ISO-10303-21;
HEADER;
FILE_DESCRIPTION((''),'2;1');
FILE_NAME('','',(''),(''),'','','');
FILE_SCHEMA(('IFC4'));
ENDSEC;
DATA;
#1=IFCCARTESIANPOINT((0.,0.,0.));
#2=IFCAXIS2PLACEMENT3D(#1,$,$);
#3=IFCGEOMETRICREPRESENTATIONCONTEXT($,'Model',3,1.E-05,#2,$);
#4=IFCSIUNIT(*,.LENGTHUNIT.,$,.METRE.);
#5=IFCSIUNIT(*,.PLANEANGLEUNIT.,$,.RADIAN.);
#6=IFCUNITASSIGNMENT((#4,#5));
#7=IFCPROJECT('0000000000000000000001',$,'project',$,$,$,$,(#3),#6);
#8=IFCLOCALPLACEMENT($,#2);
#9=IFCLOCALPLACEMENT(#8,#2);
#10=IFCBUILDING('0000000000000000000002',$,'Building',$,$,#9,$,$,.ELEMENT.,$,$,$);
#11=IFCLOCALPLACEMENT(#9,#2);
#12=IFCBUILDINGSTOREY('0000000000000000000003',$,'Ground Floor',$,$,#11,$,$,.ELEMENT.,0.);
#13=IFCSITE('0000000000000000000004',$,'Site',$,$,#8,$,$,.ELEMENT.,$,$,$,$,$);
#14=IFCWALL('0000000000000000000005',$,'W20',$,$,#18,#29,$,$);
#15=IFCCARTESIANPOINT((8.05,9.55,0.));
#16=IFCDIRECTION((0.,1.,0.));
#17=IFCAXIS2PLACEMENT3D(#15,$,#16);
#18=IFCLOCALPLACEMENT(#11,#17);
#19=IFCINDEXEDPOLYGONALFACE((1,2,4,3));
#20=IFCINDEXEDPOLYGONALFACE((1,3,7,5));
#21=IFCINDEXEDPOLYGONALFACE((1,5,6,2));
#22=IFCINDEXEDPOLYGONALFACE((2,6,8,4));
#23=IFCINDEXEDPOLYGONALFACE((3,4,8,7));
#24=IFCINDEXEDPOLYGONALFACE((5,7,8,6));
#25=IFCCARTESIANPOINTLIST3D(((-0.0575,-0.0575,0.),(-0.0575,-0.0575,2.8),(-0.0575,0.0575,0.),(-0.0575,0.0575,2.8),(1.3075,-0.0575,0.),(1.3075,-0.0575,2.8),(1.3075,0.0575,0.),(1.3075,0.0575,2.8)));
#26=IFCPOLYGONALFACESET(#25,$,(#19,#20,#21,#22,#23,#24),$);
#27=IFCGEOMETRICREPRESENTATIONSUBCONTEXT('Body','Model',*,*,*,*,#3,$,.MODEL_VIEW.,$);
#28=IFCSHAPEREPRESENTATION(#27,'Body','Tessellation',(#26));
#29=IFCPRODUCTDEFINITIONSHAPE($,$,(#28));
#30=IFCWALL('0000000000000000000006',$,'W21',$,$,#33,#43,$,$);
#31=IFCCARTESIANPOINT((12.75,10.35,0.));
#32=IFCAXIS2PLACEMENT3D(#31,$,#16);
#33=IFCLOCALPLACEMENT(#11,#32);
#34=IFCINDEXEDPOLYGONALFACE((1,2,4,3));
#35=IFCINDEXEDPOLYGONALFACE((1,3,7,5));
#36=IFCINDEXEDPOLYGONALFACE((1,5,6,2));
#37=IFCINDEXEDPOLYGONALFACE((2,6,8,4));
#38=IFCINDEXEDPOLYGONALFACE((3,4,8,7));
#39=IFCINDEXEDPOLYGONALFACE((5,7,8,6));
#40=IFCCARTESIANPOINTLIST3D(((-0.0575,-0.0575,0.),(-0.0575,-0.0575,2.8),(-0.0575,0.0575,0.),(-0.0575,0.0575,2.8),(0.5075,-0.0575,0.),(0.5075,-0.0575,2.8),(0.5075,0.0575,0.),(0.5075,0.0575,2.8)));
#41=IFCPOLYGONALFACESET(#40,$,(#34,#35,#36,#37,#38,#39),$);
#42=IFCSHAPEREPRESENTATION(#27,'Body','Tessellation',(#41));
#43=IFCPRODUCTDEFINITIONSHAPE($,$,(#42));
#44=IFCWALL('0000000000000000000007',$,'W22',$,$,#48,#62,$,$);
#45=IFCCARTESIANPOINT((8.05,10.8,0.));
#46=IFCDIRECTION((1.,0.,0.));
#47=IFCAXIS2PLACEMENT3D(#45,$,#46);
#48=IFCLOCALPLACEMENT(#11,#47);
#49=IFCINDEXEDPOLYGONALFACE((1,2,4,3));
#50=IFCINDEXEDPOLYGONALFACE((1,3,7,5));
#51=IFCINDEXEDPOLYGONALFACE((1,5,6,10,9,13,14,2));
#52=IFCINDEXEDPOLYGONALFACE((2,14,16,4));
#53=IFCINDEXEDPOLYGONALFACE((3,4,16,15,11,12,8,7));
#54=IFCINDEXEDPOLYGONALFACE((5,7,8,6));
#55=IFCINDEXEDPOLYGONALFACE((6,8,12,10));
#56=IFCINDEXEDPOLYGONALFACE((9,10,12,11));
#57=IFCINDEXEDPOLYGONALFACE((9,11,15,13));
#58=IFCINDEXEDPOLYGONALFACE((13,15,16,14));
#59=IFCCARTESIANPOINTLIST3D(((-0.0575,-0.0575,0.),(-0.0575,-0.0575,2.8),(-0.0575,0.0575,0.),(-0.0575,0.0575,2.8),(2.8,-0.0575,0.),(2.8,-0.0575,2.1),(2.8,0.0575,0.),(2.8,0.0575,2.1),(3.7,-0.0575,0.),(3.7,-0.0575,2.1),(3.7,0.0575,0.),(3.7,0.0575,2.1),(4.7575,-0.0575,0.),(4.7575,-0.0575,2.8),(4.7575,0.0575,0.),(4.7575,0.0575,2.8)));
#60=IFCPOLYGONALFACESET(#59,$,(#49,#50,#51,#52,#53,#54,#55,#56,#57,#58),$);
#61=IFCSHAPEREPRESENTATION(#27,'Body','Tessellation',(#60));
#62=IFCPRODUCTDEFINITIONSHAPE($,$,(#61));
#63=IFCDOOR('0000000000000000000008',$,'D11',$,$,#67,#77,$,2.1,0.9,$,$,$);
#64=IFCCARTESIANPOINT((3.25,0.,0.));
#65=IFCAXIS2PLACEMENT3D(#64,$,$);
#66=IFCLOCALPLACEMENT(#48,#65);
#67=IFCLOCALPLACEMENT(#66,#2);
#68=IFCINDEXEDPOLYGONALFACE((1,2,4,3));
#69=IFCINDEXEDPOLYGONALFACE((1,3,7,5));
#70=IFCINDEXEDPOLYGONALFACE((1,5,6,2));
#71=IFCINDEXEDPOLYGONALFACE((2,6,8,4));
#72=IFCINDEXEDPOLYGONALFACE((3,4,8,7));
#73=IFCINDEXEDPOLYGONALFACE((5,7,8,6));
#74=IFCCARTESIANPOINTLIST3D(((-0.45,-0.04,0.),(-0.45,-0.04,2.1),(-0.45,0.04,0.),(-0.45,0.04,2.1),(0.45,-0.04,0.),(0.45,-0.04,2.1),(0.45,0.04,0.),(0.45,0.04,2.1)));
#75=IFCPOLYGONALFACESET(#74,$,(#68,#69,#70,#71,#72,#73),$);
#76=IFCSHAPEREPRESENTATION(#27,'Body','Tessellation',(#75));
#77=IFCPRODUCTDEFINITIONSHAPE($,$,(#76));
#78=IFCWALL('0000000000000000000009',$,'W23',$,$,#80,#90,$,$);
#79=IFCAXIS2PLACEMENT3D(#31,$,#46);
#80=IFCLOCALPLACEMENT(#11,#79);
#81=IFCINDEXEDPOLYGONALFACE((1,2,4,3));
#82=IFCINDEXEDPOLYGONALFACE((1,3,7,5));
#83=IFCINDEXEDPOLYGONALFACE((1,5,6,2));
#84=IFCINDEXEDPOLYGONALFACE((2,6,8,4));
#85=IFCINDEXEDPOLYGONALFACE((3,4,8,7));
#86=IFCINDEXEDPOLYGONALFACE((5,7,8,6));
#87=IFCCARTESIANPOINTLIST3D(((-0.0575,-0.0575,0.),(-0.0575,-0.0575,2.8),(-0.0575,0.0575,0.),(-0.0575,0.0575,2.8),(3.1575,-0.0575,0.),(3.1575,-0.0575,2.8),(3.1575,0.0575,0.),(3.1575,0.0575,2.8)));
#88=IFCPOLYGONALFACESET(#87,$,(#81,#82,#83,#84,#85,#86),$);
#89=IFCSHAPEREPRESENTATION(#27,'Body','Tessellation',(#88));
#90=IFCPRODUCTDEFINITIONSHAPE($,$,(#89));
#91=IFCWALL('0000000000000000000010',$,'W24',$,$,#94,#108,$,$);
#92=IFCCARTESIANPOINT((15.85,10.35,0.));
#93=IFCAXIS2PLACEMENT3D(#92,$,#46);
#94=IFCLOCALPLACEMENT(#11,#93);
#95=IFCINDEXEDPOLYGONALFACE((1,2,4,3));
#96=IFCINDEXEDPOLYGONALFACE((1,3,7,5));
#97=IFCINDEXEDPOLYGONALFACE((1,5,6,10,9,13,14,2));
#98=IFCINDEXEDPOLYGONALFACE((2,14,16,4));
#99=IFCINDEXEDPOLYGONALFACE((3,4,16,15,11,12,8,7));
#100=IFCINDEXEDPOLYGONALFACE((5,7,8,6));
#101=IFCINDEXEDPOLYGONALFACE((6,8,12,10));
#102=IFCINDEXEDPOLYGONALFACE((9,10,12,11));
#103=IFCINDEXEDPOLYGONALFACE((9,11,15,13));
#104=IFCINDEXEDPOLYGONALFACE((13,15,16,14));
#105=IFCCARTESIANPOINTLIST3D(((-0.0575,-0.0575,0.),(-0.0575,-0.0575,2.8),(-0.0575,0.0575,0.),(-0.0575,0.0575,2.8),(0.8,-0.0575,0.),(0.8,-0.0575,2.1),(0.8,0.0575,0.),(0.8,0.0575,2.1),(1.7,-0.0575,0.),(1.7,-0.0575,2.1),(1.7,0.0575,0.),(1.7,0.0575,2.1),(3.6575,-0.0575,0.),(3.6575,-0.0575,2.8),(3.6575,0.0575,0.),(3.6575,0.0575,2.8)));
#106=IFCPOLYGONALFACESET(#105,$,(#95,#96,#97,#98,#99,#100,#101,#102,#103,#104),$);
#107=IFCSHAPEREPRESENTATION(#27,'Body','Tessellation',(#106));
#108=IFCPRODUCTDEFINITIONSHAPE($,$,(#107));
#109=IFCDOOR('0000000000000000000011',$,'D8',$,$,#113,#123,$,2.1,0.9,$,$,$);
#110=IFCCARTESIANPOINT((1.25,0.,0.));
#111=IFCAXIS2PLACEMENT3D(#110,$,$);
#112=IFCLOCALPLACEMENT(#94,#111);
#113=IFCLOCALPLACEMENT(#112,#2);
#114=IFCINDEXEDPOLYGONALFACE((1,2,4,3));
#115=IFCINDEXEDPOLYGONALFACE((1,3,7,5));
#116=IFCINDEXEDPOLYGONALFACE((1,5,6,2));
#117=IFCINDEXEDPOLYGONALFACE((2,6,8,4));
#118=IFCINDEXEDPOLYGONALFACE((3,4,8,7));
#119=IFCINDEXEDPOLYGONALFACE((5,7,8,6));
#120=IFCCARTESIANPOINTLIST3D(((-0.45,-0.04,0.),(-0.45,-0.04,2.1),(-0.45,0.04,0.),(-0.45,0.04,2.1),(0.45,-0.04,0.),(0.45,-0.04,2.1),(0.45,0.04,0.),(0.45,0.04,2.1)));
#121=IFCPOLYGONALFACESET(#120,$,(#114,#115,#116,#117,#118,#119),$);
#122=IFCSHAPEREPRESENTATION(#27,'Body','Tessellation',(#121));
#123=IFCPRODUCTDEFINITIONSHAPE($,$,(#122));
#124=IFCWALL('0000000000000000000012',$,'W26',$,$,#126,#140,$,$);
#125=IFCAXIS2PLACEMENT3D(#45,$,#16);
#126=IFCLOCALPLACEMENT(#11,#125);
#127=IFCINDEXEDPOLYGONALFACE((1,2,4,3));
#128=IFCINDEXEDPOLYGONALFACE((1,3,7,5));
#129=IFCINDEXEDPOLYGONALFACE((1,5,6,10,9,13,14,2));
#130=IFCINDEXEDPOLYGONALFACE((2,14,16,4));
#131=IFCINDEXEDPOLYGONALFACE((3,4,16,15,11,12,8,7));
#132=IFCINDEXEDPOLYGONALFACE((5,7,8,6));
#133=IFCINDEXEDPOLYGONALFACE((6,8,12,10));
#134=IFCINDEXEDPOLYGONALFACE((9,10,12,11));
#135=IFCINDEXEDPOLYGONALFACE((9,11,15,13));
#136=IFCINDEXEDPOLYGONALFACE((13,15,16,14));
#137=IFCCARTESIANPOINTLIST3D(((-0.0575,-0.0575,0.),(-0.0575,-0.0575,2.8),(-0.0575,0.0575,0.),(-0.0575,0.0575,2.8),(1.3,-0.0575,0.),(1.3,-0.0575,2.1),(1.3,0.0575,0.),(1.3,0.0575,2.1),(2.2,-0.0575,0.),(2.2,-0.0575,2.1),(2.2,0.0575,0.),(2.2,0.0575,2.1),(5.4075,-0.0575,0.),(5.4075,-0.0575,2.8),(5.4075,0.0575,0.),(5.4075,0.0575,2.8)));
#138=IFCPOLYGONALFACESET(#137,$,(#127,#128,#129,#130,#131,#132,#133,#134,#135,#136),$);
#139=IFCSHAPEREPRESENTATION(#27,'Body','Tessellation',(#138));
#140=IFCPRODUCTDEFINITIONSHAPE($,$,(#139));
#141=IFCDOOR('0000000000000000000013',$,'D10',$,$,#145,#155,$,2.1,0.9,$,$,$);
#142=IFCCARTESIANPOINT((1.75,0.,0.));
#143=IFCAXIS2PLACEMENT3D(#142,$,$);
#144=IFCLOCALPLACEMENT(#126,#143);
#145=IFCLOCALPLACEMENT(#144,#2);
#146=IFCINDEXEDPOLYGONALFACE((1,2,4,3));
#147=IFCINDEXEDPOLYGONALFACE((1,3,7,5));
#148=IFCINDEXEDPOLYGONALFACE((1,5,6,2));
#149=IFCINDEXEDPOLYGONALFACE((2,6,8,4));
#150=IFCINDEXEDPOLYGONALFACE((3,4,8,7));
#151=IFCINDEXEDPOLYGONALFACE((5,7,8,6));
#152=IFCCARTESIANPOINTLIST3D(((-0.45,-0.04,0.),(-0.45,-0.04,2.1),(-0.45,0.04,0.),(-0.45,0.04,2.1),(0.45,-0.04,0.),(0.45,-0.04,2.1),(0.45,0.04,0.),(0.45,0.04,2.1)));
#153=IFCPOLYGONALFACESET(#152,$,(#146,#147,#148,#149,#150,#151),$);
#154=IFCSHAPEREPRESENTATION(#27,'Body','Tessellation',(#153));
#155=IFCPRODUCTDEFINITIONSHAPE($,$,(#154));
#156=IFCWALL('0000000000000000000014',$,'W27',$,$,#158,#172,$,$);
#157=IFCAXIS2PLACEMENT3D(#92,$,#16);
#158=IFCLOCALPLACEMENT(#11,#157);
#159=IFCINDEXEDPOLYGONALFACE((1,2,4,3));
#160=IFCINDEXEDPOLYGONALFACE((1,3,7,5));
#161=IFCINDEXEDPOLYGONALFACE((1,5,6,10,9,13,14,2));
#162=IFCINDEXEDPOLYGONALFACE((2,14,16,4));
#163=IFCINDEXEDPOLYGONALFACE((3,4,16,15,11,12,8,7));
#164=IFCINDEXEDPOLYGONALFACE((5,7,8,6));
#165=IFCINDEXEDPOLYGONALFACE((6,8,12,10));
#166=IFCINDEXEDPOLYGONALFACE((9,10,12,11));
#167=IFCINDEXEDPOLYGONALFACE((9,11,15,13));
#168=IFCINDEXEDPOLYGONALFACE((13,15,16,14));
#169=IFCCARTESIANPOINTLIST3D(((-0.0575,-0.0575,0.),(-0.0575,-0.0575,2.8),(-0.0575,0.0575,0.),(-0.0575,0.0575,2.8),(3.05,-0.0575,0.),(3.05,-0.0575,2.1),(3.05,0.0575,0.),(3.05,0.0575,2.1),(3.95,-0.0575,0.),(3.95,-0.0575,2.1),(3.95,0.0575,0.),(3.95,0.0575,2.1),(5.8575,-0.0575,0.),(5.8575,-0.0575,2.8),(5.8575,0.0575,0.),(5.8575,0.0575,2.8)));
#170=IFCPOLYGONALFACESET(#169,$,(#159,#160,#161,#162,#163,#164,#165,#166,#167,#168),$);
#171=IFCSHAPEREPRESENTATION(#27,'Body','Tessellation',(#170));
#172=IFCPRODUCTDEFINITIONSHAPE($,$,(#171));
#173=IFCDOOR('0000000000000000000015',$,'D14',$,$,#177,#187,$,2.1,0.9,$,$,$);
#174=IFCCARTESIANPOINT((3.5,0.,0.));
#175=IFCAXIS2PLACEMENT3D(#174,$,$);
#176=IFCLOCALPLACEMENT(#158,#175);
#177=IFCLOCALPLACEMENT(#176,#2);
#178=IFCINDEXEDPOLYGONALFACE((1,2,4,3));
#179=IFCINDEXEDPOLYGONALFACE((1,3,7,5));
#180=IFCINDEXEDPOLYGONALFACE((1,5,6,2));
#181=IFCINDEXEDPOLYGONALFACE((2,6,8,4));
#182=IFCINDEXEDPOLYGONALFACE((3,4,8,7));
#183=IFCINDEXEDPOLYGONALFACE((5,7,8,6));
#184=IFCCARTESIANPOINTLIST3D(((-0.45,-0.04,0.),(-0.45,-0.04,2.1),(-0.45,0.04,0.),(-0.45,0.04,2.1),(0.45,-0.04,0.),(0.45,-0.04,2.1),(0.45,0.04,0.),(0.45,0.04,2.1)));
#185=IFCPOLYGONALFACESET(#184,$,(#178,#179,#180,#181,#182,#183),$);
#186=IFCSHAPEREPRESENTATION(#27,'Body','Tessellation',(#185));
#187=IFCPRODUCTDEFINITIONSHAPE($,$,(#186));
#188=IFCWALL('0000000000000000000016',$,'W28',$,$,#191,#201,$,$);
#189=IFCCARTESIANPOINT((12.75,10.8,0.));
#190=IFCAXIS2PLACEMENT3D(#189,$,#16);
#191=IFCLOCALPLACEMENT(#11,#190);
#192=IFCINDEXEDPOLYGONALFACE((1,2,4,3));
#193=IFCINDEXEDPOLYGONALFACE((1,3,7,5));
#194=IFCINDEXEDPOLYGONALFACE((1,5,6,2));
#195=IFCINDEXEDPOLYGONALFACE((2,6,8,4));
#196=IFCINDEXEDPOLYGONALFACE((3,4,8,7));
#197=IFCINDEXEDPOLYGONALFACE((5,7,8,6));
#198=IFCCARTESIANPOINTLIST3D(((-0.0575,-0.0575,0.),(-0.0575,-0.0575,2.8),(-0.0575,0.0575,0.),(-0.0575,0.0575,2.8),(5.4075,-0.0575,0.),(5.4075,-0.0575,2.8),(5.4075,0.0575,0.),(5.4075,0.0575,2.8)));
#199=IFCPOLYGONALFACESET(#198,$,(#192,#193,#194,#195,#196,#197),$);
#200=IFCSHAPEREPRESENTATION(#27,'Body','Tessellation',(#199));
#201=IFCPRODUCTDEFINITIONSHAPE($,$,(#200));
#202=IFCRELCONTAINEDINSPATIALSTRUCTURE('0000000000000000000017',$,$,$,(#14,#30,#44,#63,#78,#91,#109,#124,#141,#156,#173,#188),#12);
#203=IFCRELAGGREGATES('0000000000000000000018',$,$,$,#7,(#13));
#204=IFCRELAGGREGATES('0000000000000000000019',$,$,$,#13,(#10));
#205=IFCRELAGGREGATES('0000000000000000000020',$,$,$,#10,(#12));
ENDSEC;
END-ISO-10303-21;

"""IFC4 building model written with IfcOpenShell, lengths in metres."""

from ifc_helpers import new_model, si_unit, frame, frame_2d, origin, origin_2d, place, context, subcontext, project, spatial, rectangle, extrude, element, fill, save


model = new_model("IFC4")

# Units and contexts
model_context = context("Model", 3, precision=1e-05, world=origin())
body_context = subcontext(model_context, "Body", "Model", "MODEL_VIEW")
ifc_project = project(units=[si_unit("LENGTHUNIT", "METRE"), si_unit("PLANEANGLEUNIT", "RADIAN")], contexts=[model_context])

# Site, building, storey
site_placement = place(None, origin())
site = spatial("IfcSite", under=ifc_project, at=site_placement, Name="Site", CompositionType="ELEMENT")
building_placement = place(site_placement, origin())
building = spatial("IfcBuilding", under=site, at=building_placement, Name="Building", CompositionType="ELEMENT")
storey_placement = place(building_placement, origin())
storey = spatial("IfcBuildingStorey", under=building, at=storey_placement, Name="Ground Floor", CompositionType="ELEMENT", Elevation=0.0)

# Walls
wall_1_placement = place(storey_placement, frame((8.05, 9.55, 0.0), x_axis=(0.0, 1.0, 0.0)))
element("IfcWall", 1, at=wall_1_placement, inside=storey, Name="W20", context=body_context, shape_type="SweptSolid", body=[
    extrude(rectangle(XDim=1.365, YDim=0.115, at=frame_2d((0.625, 0.0))), origin(), (0.0, 0.0, 1.0), 2.8),
])
wall_2_placement = place(storey_placement, frame((12.75, 10.35, 0.0), x_axis=(0.0, 1.0, 0.0)))
element("IfcWall", 2, at=wall_2_placement, inside=storey, Name="W21", context=body_context, shape_type="SweptSolid", body=[
    extrude(rectangle(XDim=0.565, YDim=0.115, at=frame_2d((0.225, 0.0))), origin(), (0.0, 0.0, 1.0), 2.8),
])

# Wall, opening, door
wall_3_placement = place(storey_placement, frame((8.05, 10.8, 0.0), x_axis=(1.0, 0.0, 0.0)))
wall_3 = element("IfcWall", 3, at=wall_3_placement, inside=storey, Name="W22", context=body_context, shape_type="SweptSolid", body=[
    extrude(rectangle(XDim=4.815, YDim=0.115, at=frame_2d((2.35, 0.0))), origin(), (0.0, 0.0, 1.0), 2.8),
])
opening_1_placement = place(wall_3_placement, frame((3.25, 0.0, 0.0)))
opening_1 = element("IfcOpeningElement", 4, at=opening_1_placement, cuts=wall_3, context=body_context, shape_type="SweptSolid", body=[
    extrude(rectangle(XDim=0.9, YDim=0.215, at=origin_2d()), origin(), (0.0, 0.0, 1.0), 2.1),
])
door_1_placement = place(opening_1_placement, origin())
door_1 = element("IfcDoor", 5, at=door_1_placement, inside=storey, Name="D11", OverallHeight=2.1, OverallWidth=0.9, context=body_context, shape_type="SweptSolid", body=[
    extrude(rectangle(XDim=0.9, YDim=0.08, at=origin_2d()), origin(), (0.0, 0.0, 1.0), 2.1),
])
fill(opening_1, door_1)

# Wall
wall_4_placement = place(storey_placement, frame((12.75, 10.35, 0.0), x_axis=(1.0, 0.0, 0.0)))
element("IfcWall", 6, at=wall_4_placement, inside=storey, Name="W23", context=body_context, shape_type="SweptSolid", body=[
    extrude(rectangle(XDim=3.215, YDim=0.115, at=frame_2d((1.55, 0.0))), origin(), (0.0, 0.0, 1.0), 2.8),
])

# Walls, openings, doors
wall_5_placement = place(storey_placement, frame((15.85, 10.35, 0.0), x_axis=(1.0, 0.0, 0.0)))
wall_5 = element("IfcWall", 7, at=wall_5_placement, inside=storey, Name="W24", context=body_context, shape_type="SweptSolid", body=[
    extrude(rectangle(XDim=3.715, YDim=0.115, at=frame_2d((1.8, 0.0))), origin(), (0.0, 0.0, 1.0), 2.8),
])
opening_2_placement = place(wall_5_placement, frame((1.25, 0.0, 0.0)))
opening_2 = element("IfcOpeningElement", 8, at=opening_2_placement, cuts=wall_5, context=body_context, shape_type="SweptSolid", body=[
    extrude(rectangle(XDim=0.9, YDim=0.215, at=origin_2d()), origin(), (0.0, 0.0, 1.0), 2.1),
])
door_2_placement = place(opening_2_placement, origin())
door_2 = element("IfcDoor", 9, at=door_2_placement, inside=storey, Name="D8", OverallHeight=2.1, OverallWidth=0.9, context=body_context, shape_type="SweptSolid", body=[
    extrude(rectangle(XDim=0.9, YDim=0.08, at=origin_2d()), origin(), (0.0, 0.0, 1.0), 2.1),
])
fill(opening_2, door_2)
wall_6_placement = place(storey_placement, frame((8.05, 10.8, 0.0), x_axis=(0.0, 1.0, 0.0)))
wall_6 = element("IfcWall", 10, at=wall_6_placement, inside=storey, Name="W26", context=body_context, shape_type="SweptSolid", body=[
    extrude(rectangle(XDim=5.465, YDim=0.115, at=frame_2d((2.675, 0.0))), origin(), (0.0, 0.0, 1.0), 2.8),
])
opening_3_placement = place(wall_6_placement, frame((1.75, 0.0, 0.0)))
opening_3 = element("IfcOpeningElement", 11, at=opening_3_placement, cuts=wall_6, context=body_context, shape_type="SweptSolid", body=[
    extrude(rectangle(XDim=0.9, YDim=0.215, at=origin_2d()), origin(), (0.0, 0.0, 1.0), 2.1),
])
door_3_placement = place(opening_3_placement, origin())
door_3 = element("IfcDoor", 12, at=door_3_placement, inside=storey, Name="D10", OverallHeight=2.1, OverallWidth=0.9, context=body_context, shape_type="SweptSolid", body=[
    extrude(rectangle(XDim=0.9, YDim=0.08, at=origin_2d()), origin(), (0.0, 0.0, 1.0), 2.1),
])
fill(opening_3, door_3)
wall_7_placement = place(storey_placement, frame((15.85, 10.35, 0.0), x_axis=(0.0, 1.0, 0.0)))
wall_7 = element("IfcWall", 13, at=wall_7_placement, inside=storey, Name="W27", context=body_context, shape_type="SweptSolid", body=[
    extrude(rectangle(XDim=5.915, YDim=0.115, at=frame_2d((2.9, 0.0))), origin(), (0.0, 0.0, 1.0), 2.8),
])
opening_4_placement = place(wall_7_placement, frame((3.5, 0.0, 0.0)))
opening_4 = element("IfcOpeningElement", 14, at=opening_4_placement, cuts=wall_7, context=body_context, shape_type="SweptSolid", body=[
    extrude(rectangle(XDim=0.9, YDim=0.215, at=origin_2d()), origin(), (0.0, 0.0, 1.0), 2.1),
])
door_4_placement = place(opening_4_placement, origin())
door_4 = element("IfcDoor", 15, at=door_4_placement, inside=storey, Name="D14", OverallHeight=2.1, OverallWidth=0.9, context=body_context, shape_type="SweptSolid", body=[
    extrude(rectangle(XDim=0.9, YDim=0.08, at=origin_2d()), origin(), (0.0, 0.0, 1.0), 2.1),
])
fill(opening_4, door_4)

# Wall
wall_8_placement = place(storey_placement, frame((12.75, 10.8, 0.0), x_axis=(0.0, 1.0, 0.0)))
element("IfcWall", 16, at=wall_8_placement, inside=storey, Name="W28", context=body_context, shape_type="SweptSolid", body=[
    extrude(rectangle(XDim=5.465, YDim=0.115, at=frame_2d((2.675, 0.0))), origin(), (0.0, 0.0, 1.0), 2.8),
])

save(model, "model.ifc")
